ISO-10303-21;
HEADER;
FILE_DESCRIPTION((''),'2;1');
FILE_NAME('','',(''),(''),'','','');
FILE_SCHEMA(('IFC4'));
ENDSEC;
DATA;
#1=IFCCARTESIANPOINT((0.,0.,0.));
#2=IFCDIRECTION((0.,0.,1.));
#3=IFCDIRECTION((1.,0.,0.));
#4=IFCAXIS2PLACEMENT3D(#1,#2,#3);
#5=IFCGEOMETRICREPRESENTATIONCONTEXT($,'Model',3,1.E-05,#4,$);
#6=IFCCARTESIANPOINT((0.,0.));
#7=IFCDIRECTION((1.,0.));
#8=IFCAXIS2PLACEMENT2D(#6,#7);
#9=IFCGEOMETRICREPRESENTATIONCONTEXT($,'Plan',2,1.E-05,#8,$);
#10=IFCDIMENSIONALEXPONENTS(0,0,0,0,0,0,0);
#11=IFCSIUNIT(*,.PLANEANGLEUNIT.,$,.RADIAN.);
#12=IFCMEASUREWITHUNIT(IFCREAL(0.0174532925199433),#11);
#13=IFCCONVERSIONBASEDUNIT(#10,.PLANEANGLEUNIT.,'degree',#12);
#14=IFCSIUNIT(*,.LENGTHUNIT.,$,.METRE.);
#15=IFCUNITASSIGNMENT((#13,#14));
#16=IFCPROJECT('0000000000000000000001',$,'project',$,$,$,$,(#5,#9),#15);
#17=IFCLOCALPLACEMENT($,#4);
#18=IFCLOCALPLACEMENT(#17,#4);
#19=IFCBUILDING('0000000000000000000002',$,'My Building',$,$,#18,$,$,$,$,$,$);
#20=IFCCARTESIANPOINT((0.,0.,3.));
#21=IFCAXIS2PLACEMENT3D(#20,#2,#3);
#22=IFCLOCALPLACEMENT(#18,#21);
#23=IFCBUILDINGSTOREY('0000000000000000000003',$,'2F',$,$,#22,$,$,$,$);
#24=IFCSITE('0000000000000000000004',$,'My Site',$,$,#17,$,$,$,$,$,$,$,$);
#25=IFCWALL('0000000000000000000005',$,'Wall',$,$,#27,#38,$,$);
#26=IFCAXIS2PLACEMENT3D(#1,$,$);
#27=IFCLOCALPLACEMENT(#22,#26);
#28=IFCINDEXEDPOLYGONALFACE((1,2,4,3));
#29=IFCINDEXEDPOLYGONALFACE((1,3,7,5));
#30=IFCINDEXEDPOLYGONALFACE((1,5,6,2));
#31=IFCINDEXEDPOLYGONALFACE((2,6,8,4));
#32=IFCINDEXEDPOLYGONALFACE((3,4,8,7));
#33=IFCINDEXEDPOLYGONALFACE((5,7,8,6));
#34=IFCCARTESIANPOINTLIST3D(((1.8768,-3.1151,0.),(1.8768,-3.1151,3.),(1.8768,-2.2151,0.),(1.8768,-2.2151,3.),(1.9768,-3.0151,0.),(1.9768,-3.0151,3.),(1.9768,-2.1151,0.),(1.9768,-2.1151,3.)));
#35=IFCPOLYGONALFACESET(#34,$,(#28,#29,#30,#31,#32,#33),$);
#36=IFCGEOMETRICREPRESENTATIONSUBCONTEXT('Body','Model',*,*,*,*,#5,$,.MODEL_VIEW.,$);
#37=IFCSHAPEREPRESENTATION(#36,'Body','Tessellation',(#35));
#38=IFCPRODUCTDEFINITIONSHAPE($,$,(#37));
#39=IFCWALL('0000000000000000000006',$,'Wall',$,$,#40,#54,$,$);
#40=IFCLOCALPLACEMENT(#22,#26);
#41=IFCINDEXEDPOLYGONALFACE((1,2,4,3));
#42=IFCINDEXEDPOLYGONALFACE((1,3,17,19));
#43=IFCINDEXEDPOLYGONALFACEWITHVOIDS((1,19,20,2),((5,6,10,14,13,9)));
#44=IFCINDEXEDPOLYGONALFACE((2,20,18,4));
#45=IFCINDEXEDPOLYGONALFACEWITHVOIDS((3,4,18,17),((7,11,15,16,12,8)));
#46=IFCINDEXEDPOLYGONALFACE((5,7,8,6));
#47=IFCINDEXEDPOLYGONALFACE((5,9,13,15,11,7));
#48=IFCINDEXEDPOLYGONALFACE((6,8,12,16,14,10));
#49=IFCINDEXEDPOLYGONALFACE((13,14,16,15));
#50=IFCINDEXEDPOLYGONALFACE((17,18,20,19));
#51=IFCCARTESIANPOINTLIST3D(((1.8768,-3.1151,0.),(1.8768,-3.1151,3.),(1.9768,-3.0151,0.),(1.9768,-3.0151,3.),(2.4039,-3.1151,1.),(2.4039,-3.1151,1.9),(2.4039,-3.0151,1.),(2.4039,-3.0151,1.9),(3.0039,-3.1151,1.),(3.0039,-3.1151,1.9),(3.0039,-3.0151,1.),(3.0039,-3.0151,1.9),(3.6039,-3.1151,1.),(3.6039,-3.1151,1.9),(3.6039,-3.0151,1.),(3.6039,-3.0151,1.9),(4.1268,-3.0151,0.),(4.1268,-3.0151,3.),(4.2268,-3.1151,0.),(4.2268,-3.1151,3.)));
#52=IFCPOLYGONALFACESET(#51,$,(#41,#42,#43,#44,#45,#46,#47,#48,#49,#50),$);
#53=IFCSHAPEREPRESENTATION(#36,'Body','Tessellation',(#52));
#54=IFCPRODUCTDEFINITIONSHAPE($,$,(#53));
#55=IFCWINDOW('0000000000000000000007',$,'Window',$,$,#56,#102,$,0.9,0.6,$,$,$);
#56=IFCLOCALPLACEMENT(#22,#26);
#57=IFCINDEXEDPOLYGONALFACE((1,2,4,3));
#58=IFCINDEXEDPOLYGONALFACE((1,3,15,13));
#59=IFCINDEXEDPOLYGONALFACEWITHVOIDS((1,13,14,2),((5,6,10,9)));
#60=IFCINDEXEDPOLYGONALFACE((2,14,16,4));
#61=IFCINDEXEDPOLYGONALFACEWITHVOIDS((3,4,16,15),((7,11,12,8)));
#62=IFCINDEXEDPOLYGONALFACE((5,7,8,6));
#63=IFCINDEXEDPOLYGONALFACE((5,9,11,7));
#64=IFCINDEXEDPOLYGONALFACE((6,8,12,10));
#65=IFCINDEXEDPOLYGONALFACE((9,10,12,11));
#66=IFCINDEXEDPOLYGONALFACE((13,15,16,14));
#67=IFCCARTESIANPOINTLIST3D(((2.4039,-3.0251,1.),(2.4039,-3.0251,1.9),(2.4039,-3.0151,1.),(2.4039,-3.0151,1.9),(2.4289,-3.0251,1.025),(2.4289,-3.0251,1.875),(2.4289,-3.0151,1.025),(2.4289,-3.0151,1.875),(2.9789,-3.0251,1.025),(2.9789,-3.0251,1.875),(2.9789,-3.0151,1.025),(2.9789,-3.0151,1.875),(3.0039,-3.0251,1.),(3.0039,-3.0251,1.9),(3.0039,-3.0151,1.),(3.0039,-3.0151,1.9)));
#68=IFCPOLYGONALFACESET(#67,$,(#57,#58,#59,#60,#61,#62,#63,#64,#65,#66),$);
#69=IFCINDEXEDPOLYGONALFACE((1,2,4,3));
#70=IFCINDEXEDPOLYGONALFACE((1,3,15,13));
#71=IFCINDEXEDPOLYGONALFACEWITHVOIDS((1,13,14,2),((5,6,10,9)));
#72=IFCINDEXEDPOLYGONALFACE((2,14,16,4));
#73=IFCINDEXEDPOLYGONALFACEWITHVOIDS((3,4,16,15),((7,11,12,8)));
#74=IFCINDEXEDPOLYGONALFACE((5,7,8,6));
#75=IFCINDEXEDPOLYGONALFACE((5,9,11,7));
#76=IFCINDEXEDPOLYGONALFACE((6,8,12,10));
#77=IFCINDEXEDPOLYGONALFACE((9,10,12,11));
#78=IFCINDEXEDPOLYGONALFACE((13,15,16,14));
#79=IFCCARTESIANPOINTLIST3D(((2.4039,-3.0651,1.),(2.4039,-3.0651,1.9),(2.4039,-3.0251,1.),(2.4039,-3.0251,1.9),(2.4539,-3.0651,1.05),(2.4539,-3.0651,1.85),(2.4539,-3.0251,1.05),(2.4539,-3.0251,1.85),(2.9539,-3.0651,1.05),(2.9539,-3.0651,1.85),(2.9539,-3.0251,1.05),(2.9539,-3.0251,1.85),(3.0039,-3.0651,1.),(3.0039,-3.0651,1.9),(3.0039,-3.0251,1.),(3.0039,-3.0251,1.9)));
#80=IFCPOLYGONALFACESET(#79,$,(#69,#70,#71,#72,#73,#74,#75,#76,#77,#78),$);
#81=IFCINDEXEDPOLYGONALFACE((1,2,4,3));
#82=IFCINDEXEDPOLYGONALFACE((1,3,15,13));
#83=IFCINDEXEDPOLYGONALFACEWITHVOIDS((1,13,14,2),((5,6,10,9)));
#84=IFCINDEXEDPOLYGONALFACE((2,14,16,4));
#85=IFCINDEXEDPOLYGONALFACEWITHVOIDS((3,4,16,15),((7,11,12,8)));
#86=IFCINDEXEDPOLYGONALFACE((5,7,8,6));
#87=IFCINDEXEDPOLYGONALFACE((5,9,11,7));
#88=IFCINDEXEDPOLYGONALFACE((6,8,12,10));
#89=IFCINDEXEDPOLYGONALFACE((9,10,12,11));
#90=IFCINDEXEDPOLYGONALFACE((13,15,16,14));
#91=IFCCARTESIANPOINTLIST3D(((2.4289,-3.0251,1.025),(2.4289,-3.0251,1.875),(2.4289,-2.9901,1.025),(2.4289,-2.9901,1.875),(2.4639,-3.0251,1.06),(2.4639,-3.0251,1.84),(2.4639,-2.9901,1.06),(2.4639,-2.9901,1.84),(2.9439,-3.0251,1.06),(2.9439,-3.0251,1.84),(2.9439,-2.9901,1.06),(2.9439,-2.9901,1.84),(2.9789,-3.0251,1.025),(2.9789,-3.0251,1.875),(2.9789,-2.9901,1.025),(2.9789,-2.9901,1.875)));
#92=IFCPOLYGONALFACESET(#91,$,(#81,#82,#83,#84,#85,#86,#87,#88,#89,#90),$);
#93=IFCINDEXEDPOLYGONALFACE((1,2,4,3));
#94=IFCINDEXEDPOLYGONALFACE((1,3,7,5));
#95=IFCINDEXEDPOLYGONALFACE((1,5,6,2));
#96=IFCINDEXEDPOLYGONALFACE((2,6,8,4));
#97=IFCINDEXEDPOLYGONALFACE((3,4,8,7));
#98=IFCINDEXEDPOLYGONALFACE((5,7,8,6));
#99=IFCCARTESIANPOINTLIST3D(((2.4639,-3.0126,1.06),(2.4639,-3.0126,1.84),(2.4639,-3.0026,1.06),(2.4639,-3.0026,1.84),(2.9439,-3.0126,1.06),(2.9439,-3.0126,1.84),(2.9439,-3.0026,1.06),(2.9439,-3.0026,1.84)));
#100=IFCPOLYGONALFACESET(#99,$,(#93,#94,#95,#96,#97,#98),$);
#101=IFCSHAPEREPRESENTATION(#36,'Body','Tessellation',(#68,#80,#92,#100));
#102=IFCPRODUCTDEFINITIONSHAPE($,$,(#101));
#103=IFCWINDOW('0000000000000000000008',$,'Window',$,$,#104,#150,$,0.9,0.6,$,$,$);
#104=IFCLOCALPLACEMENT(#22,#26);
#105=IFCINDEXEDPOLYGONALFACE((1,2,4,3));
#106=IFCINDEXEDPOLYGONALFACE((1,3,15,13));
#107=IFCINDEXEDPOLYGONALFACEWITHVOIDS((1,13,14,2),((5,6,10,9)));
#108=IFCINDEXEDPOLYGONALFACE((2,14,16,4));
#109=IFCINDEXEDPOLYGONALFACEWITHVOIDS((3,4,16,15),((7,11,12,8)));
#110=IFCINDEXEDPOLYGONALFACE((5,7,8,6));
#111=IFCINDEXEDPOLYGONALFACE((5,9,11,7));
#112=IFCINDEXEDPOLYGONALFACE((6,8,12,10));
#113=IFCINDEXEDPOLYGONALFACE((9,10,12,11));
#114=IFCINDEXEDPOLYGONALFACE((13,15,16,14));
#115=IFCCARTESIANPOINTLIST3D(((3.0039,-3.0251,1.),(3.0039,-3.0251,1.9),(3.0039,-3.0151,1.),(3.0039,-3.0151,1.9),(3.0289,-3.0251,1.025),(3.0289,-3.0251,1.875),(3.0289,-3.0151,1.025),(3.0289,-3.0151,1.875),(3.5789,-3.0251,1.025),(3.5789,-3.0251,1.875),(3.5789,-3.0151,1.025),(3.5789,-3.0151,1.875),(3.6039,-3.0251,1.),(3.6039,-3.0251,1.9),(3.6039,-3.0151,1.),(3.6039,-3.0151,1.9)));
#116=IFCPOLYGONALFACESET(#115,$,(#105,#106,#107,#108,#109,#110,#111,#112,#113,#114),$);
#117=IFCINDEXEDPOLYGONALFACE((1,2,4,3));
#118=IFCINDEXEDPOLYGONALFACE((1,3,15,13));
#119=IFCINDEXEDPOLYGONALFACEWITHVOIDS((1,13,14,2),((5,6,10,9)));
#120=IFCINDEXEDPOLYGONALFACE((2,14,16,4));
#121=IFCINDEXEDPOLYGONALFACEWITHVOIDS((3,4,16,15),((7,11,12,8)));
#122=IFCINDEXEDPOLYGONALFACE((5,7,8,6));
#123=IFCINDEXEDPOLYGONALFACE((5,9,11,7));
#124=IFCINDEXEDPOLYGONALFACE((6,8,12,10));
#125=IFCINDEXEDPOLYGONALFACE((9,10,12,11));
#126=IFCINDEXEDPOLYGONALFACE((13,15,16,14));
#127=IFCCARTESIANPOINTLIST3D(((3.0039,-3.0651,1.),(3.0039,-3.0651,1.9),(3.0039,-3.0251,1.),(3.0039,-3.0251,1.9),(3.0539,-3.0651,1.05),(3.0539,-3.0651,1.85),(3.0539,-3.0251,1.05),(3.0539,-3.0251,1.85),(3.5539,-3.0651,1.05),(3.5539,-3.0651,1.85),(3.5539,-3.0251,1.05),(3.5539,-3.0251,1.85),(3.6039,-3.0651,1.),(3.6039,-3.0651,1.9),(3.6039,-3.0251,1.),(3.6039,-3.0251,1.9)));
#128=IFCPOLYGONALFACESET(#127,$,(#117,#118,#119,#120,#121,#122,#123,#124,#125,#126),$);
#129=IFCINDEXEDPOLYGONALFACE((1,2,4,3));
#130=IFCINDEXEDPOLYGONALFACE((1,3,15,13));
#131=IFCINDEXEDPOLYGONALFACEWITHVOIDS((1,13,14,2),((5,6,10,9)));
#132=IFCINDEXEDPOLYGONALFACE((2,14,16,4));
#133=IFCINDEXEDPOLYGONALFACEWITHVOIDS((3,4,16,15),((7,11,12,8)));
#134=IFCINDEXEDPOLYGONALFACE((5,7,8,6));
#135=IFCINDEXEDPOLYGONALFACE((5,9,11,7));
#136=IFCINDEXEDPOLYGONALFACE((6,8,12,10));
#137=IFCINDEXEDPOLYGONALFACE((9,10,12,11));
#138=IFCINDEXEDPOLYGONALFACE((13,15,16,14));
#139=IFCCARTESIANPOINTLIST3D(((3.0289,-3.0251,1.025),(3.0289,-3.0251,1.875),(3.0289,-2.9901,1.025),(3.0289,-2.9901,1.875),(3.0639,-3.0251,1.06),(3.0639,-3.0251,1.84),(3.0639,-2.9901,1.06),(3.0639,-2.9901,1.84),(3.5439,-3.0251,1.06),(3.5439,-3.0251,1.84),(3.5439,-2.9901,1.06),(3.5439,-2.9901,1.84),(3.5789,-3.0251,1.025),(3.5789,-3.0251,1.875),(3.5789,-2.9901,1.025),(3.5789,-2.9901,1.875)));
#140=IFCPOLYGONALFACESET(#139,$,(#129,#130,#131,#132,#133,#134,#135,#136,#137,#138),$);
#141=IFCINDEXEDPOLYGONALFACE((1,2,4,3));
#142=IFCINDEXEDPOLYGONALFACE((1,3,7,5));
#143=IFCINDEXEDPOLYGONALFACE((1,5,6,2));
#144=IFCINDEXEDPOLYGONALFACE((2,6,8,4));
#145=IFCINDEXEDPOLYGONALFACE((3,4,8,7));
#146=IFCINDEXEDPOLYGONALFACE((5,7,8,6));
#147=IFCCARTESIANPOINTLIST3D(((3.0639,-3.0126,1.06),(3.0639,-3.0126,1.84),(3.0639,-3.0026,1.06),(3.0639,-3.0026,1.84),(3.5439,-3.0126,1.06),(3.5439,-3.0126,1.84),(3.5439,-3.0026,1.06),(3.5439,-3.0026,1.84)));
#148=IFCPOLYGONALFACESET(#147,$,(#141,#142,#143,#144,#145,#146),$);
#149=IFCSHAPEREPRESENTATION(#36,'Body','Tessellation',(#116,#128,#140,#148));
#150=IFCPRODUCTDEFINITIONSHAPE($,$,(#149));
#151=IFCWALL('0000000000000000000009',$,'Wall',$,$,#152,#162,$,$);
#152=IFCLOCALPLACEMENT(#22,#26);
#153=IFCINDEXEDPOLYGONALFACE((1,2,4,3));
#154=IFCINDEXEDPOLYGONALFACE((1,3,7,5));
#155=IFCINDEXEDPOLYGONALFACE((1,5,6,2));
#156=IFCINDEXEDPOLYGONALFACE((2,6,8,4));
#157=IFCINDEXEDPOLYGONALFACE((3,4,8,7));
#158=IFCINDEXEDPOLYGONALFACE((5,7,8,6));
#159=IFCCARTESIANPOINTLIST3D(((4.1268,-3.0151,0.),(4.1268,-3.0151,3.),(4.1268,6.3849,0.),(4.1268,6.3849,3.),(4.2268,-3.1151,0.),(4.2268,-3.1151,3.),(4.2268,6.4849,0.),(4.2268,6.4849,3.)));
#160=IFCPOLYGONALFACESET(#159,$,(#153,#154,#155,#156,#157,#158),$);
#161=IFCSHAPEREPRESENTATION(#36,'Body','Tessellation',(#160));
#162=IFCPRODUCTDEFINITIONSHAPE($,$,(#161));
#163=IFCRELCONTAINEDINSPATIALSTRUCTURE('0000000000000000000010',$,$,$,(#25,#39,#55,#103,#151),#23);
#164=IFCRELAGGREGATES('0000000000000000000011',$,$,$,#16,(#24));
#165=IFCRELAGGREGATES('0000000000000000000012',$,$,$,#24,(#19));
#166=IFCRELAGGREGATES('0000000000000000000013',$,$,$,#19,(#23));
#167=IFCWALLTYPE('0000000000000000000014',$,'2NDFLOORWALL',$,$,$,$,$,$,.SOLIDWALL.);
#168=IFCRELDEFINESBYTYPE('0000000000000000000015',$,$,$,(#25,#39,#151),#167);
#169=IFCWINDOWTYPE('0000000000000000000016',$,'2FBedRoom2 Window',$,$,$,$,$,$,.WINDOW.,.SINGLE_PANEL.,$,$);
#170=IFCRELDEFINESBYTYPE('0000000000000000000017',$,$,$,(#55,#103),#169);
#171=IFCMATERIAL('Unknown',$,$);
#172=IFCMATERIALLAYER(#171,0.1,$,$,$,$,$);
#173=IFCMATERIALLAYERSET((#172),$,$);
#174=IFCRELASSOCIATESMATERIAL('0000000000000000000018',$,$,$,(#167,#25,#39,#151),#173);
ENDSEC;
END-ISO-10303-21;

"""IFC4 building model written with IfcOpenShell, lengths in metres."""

from ifc_helpers import new_model, entity, si_unit, converted_unit, frame, origin_with_axes, origin_2d_with_axis, place, context, subcontext, project, spatial, line, indexed_curve, outline, extrude, shape, source, transform, mapped, material, layer, layer_set, layer_usage, type_object, type_shapes, element, fill, save


model = new_model("IFC4")

# Units and contexts
model_context = context("Model", 3, precision=1e-05, world=origin_with_axes())
plan_context = context("Plan", 2, precision=1e-05, world=origin_2d_with_axis())
body_context_1 = subcontext(model_context, "Body", "Model", "MODEL_VIEW")
body_context_2 = subcontext(plan_context, "Body", "Plan", "PLAN_VIEW")
ifc_project = project(units=[converted_unit("PLANEANGLEUNIT", "degree", entity("IfcReal", 0.0174532925199433), si_unit("PLANEANGLEUNIT", "RADIAN"), dimensions=[0, 0, 0, 0, 0, 0, 0]), si_unit("LENGTHUNIT", "METRE")], contexts=[model_context, plan_context])

# Site, building, storey
site_placement = place(None, origin_with_axes())
site = spatial("IfcSite", under=ifc_project, at=site_placement, Name="My Site")
building_placement = place(site_placement, origin_with_axes())
building = spatial("IfcBuilding", under=site, at=building_placement, Name="My Building")
storey_placement = place(building_placement, frame((0.0, 0.0, 3.0), z_axis=(0.0, 0.0, 1.0), x_axis=(1.0, 0.0, 0.0)))
storey = spatial("IfcBuildingStorey", under=building, at=storey_placement, Name="2F")

# Shared definitions
ifc_material = material(Name="Unknown")

# Shared definitions
ifc_layer_1 = layer(ifc_material, 0.1)
ifc_layer_set_1 = layer_set([ifc_layer_1])
wall_type_1 = type_object("IfcWallType", Name="2NDFLOORWALL", PredefinedType="SOLIDWALL", material=ifc_layer_set_1)

# Wall
ifc_layer_usage_1 = layer_usage(ifc_layer_set_1, "AXIS2", "POSITIVE", 0.0)
wall_1_placement = place(storey_placement, frame((1.8768, -2.2151, 0.0), z_axis=(0.0, 0.0, 1.0), x_axis=(0.0, -1.0, 0.0)))
element("IfcWall", 1, at=wall_1_placement, inside=storey, type_object=wall_type_1, material=ifc_layer_usage_1, Name="Wall", context=body_context_1, shape_type="SweptSolid", body=[
    extrude(outline(indexed_curve([(0.0, 0.0), (-0.1, 0.1), (0.8, 0.1), (0.9, 0.0)], segments=[line(1, 2, 3, 4, 1)])), origin_with_axes(), (0.0, 0.0, 1.0), 3.0),
])

# Wall, openings, windows
ifc_layer_usage_2 = layer_usage(ifc_layer_set_1, "AXIS2", "POSITIVE", 0.0)
wall_2_placement = place(storey_placement, frame((1.8768, -3.1151, 0.0), z_axis=(0.0, 0.0, 1.0), x_axis=(1.0, 0.0, 0.0)))
wall_2 = element("IfcWall", 2, at=wall_2_placement, inside=storey, type_object=wall_type_1, material=ifc_layer_usage_2, Name="Wall", context=body_context_1, shape_type="SweptSolid", body=[
    extrude(outline(indexed_curve([(0.0, 0.0), (0.1, 0.1), (2.25, 0.1), (2.35, 0.0)], segments=[line(1, 2, 3, 4, 1)])), origin_with_axes(), (0.0, 0.0, 1.0), 3.0),
])
shared_shape_1 = source(origin_with_axes(), body_context_1, "Body", "SweptSolid", [
    extrude(outline(indexed_curve([(0.0, 0.0), (0.6, 0.0), (0.6, 0.9), (0.0, 0.9)], segments=[line(1, 2, 3, 4, 1)])), frame((0.0, -0.6, 0.0), z_axis=(0.0, -1.0, 0.0), x_axis=(1.0, 0.0, 0.0)), (0.0, 0.0, -1.0), 1.2),
])
opening_1_placement = place(wall_2_placement, frame((0.5271, 0.0, 1.0), z_axis=(0.0, 0.0, 1.0), x_axis=(1.0, 0.0, 0.0)))
opening_1 = element("IfcOpeningElement", 3, at=opening_1_placement, cuts=wall_2, PredefinedType="OPENING", context=body_context_1, shape_type="MappedRepresentation", body=[
    mapped(shared_shape_1, transform((0.0, 0.0, 0.0), x_axis=(1.0, 0.0, 0.0), y_axis=(0.0, 1.0, 0.0), z_axis=(0.0, 0.0, 1.0), scale=1.0)),
])
opening_2_placement = place(wall_2_placement, frame((1.1271, 0.0, 1.0), z_axis=(0.0, 0.0, 1.0), x_axis=(1.0, 0.0, 0.0)))
opening_2 = element("IfcOpeningElement", 4, at=opening_2_placement, cuts=wall_2, PredefinedType="OPENING", context=body_context_1, shape_type="MappedRepresentation", body=[
    mapped(shared_shape_1, transform((0.0, 0.0, 0.0), x_axis=(1.0, 0.0, 0.0), y_axis=(0.0, 1.0, 0.0), z_axis=(0.0, 0.0, 1.0), scale=1.0)),
])
window_type = type_object("IfcWindowType", Name="2FBedRoom2 Window", PartitioningType="SINGLE_PANEL", PredefinedType="WINDOW")
shared_shape_2 = source(origin_with_axes(), body_context_1, "Body", "SweptSolid", [
    extrude(outline(indexed_curve([(0.0, 0.0), (0.6, 0.0), (0.6, 0.9), (0.0, 0.9)], segments=[line(1, 2, 3, 4, 1)]), holes=[indexed_curve([(0.025, 0.025), (0.575, 0.025), (0.575, 0.875), (0.025, 0.875)], segments=[line(1, 2, 3, 4, 1)])]), frame((0.0, 0.09, 0.0), z_axis=(0.0, -1.0, 0.0), x_axis=(1.0, 0.0, 0.0)), (0.0, 0.0, -1.0), 0.01),
    extrude(outline(indexed_curve([(0.0, 0.0), (0.6, 0.0), (0.6, 0.9), (0.0, 0.9)], segments=[line(1, 2, 3, 4, 1)]), holes=[indexed_curve([(0.05, 0.05), (0.55, 0.05), (0.55, 0.85), (0.05, 0.85)], segments=[line(1, 2, 3, 4, 1)])]), frame((0.0, 0.05, 0.0), z_axis=(0.0, -1.0, 0.0), x_axis=(1.0, 0.0, 0.0)), (0.0, 0.0, -1.0), 0.04),
    extrude(outline(indexed_curve([(0.0, 0.0), (0.55, 0.0), (0.55, 0.85), (0.0, 0.85)], segments=[line(1, 2, 3, 4, 1)]), holes=[indexed_curve([(0.035, 0.035), (0.515, 0.035), (0.515, 0.815), (0.035, 0.815)], segments=[line(1, 2, 3, 4, 1)])]), frame((0.025, 0.09, 0.025), z_axis=(0.0, -1.0, 0.0), x_axis=(1.0, 0.0, 0.0)), (0.0, 0.0, -1.0), 0.035),
    extrude(outline(indexed_curve([(0.035, 0.035), (0.515, 0.035), (0.515, 0.815), (0.035, 0.815)], segments=[line(1, 2, 3, 4, 1)])), frame((0.025, 0.1025, 0.025), z_axis=(0.0, -1.0, 0.0), x_axis=(1.0, 0.0, 0.0)), (0.0, 0.0, -1.0), 0.01),
])
shared_shape_3 = source(origin_with_axes(), body_context_2, "Body", "Curve2D", [
    entity("IfcIndexedPolyCurve", entity("IfcCartesianPointList2D", [[0.05, 0.05], [0.55, 0.05]])),
    entity("IfcIndexedPolyCurve", entity("IfcCartesianPointList2D", [[0.0, 0.1], [0.025, 0.1], [0.025, 0.09], [0.05, 0.09], [0.05, 0.05], [0.0, 0.05]]), [entity("IfcLineIndex", [1, 2, 3, 4, 5, 6, 1])]),
    entity("IfcIndexedPolyCurve", entity("IfcCartesianPointList2D", [[0.6, 0.1], [0.575, 0.1], [0.575, 0.09], [0.55, 0.09], [0.55, 0.05], [0.6, 0.05]]), [entity("IfcLineIndex", [1, 2, 3, 4, 5, 6, 1])]),
    entity("IfcIndexedPolyCurve", entity("IfcCartesianPointList2D", [[0.025, 0.09], [0.06, 0.09], [0.06, 0.125], [0.025, 0.125]]), [entity("IfcLineIndex", [1, 2, 3, 4, 1])]),
    entity("IfcIndexedPolyCurve", entity("IfcCartesianPointList2D", [[0.575, 0.09], [0.54, 0.09], [0.54, 0.125], [0.575, 0.125]]), [entity("IfcLineIndex", [1, 2, 3, 4, 1])]),
    entity("IfcIndexedPolyCurve", entity("IfcCartesianPointList2D", [[0.06, 0.09], [0.54, 0.09]])),
    entity("IfcIndexedPolyCurve", entity("IfcCartesianPointList2D", [[0.06, 0.125], [0.54, 0.125]])),
    entity("IfcIndexedPolyCurve", entity("IfcCartesianPointList2D", [[0.06, 0.1075], [0.54, 0.1075]])),
])
type_shapes(window_type, [shared_shape_2, shared_shape_3])
window_1_placement = place(opening_1_placement, origin_with_axes())
window_1 = element("IfcWindow", 5, at=window_1_placement, inside=storey, type_object=window_type, Name="Window", OverallHeight=0.9, OverallWidth=0.6, shapes=[
    shape(body_context_1, "Body", "MappedRepresentation", [mapped(shared_shape_2, transform((0.0, 0.0, 0.0), x_axis=(1.0, 0.0, 0.0), y_axis=(0.0, 1.0, 0.0), z_axis=(0.0, 0.0, 1.0), scale=1.0))]),
    shape(body_context_2, "Body", "MappedRepresentation", [mapped(shared_shape_3, transform((0.0, 0.0, 0.0), x_axis=(1.0, 0.0, 0.0), y_axis=(0.0, 1.0, 0.0), z_axis=(0.0, 0.0, 1.0), scale=1.0))]),
])
fill(opening_1, window_1)
window_2_placement = place(opening_2_placement, origin_with_axes())
window_2 = element("IfcWindow", 6, at=window_2_placement, inside=storey, type_object=window_type, Name="Window", OverallHeight=0.9, OverallWidth=0.6, shapes=[
    shape(body_context_1, "Body", "MappedRepresentation", [mapped(shared_shape_2, transform((0.0, 0.0, 0.0), x_axis=(1.0, 0.0, 0.0), y_axis=(0.0, 1.0, 0.0), z_axis=(0.0, 0.0, 1.0), scale=1.0))]),
    shape(body_context_2, "Body", "MappedRepresentation", [mapped(shared_shape_3, transform((0.0, 0.0, 0.0), x_axis=(1.0, 0.0, 0.0), y_axis=(0.0, 1.0, 0.0), z_axis=(0.0, 0.0, 1.0), scale=1.0))]),
])
fill(opening_2, window_2)

# Wall
ifc_layer_usage_3 = layer_usage(ifc_layer_set_1, "AXIS2", "POSITIVE", 0.0)
wall_3_placement = place(storey_placement, frame((4.2268, -3.1151, 0.0), z_axis=(0.0, 0.0, 1.0), x_axis=(0.0, 1.0, 0.0)))
element("IfcWall", 7, at=wall_3_placement, inside=storey, type_object=wall_type_1, material=ifc_layer_usage_3, Name="Wall", context=body_context_1, shape_type="SweptSolid", body=[
    extrude(outline(indexed_curve([(0.0, 0.0), (0.1, 0.1), (9.5, 0.1), (9.6, 0.0)], segments=[line(1, 2, 3, 4, 1)])), origin_with_axes(), (0.0, 0.0, 1.0), 3.0),
])

save(model, "model.ifc")
